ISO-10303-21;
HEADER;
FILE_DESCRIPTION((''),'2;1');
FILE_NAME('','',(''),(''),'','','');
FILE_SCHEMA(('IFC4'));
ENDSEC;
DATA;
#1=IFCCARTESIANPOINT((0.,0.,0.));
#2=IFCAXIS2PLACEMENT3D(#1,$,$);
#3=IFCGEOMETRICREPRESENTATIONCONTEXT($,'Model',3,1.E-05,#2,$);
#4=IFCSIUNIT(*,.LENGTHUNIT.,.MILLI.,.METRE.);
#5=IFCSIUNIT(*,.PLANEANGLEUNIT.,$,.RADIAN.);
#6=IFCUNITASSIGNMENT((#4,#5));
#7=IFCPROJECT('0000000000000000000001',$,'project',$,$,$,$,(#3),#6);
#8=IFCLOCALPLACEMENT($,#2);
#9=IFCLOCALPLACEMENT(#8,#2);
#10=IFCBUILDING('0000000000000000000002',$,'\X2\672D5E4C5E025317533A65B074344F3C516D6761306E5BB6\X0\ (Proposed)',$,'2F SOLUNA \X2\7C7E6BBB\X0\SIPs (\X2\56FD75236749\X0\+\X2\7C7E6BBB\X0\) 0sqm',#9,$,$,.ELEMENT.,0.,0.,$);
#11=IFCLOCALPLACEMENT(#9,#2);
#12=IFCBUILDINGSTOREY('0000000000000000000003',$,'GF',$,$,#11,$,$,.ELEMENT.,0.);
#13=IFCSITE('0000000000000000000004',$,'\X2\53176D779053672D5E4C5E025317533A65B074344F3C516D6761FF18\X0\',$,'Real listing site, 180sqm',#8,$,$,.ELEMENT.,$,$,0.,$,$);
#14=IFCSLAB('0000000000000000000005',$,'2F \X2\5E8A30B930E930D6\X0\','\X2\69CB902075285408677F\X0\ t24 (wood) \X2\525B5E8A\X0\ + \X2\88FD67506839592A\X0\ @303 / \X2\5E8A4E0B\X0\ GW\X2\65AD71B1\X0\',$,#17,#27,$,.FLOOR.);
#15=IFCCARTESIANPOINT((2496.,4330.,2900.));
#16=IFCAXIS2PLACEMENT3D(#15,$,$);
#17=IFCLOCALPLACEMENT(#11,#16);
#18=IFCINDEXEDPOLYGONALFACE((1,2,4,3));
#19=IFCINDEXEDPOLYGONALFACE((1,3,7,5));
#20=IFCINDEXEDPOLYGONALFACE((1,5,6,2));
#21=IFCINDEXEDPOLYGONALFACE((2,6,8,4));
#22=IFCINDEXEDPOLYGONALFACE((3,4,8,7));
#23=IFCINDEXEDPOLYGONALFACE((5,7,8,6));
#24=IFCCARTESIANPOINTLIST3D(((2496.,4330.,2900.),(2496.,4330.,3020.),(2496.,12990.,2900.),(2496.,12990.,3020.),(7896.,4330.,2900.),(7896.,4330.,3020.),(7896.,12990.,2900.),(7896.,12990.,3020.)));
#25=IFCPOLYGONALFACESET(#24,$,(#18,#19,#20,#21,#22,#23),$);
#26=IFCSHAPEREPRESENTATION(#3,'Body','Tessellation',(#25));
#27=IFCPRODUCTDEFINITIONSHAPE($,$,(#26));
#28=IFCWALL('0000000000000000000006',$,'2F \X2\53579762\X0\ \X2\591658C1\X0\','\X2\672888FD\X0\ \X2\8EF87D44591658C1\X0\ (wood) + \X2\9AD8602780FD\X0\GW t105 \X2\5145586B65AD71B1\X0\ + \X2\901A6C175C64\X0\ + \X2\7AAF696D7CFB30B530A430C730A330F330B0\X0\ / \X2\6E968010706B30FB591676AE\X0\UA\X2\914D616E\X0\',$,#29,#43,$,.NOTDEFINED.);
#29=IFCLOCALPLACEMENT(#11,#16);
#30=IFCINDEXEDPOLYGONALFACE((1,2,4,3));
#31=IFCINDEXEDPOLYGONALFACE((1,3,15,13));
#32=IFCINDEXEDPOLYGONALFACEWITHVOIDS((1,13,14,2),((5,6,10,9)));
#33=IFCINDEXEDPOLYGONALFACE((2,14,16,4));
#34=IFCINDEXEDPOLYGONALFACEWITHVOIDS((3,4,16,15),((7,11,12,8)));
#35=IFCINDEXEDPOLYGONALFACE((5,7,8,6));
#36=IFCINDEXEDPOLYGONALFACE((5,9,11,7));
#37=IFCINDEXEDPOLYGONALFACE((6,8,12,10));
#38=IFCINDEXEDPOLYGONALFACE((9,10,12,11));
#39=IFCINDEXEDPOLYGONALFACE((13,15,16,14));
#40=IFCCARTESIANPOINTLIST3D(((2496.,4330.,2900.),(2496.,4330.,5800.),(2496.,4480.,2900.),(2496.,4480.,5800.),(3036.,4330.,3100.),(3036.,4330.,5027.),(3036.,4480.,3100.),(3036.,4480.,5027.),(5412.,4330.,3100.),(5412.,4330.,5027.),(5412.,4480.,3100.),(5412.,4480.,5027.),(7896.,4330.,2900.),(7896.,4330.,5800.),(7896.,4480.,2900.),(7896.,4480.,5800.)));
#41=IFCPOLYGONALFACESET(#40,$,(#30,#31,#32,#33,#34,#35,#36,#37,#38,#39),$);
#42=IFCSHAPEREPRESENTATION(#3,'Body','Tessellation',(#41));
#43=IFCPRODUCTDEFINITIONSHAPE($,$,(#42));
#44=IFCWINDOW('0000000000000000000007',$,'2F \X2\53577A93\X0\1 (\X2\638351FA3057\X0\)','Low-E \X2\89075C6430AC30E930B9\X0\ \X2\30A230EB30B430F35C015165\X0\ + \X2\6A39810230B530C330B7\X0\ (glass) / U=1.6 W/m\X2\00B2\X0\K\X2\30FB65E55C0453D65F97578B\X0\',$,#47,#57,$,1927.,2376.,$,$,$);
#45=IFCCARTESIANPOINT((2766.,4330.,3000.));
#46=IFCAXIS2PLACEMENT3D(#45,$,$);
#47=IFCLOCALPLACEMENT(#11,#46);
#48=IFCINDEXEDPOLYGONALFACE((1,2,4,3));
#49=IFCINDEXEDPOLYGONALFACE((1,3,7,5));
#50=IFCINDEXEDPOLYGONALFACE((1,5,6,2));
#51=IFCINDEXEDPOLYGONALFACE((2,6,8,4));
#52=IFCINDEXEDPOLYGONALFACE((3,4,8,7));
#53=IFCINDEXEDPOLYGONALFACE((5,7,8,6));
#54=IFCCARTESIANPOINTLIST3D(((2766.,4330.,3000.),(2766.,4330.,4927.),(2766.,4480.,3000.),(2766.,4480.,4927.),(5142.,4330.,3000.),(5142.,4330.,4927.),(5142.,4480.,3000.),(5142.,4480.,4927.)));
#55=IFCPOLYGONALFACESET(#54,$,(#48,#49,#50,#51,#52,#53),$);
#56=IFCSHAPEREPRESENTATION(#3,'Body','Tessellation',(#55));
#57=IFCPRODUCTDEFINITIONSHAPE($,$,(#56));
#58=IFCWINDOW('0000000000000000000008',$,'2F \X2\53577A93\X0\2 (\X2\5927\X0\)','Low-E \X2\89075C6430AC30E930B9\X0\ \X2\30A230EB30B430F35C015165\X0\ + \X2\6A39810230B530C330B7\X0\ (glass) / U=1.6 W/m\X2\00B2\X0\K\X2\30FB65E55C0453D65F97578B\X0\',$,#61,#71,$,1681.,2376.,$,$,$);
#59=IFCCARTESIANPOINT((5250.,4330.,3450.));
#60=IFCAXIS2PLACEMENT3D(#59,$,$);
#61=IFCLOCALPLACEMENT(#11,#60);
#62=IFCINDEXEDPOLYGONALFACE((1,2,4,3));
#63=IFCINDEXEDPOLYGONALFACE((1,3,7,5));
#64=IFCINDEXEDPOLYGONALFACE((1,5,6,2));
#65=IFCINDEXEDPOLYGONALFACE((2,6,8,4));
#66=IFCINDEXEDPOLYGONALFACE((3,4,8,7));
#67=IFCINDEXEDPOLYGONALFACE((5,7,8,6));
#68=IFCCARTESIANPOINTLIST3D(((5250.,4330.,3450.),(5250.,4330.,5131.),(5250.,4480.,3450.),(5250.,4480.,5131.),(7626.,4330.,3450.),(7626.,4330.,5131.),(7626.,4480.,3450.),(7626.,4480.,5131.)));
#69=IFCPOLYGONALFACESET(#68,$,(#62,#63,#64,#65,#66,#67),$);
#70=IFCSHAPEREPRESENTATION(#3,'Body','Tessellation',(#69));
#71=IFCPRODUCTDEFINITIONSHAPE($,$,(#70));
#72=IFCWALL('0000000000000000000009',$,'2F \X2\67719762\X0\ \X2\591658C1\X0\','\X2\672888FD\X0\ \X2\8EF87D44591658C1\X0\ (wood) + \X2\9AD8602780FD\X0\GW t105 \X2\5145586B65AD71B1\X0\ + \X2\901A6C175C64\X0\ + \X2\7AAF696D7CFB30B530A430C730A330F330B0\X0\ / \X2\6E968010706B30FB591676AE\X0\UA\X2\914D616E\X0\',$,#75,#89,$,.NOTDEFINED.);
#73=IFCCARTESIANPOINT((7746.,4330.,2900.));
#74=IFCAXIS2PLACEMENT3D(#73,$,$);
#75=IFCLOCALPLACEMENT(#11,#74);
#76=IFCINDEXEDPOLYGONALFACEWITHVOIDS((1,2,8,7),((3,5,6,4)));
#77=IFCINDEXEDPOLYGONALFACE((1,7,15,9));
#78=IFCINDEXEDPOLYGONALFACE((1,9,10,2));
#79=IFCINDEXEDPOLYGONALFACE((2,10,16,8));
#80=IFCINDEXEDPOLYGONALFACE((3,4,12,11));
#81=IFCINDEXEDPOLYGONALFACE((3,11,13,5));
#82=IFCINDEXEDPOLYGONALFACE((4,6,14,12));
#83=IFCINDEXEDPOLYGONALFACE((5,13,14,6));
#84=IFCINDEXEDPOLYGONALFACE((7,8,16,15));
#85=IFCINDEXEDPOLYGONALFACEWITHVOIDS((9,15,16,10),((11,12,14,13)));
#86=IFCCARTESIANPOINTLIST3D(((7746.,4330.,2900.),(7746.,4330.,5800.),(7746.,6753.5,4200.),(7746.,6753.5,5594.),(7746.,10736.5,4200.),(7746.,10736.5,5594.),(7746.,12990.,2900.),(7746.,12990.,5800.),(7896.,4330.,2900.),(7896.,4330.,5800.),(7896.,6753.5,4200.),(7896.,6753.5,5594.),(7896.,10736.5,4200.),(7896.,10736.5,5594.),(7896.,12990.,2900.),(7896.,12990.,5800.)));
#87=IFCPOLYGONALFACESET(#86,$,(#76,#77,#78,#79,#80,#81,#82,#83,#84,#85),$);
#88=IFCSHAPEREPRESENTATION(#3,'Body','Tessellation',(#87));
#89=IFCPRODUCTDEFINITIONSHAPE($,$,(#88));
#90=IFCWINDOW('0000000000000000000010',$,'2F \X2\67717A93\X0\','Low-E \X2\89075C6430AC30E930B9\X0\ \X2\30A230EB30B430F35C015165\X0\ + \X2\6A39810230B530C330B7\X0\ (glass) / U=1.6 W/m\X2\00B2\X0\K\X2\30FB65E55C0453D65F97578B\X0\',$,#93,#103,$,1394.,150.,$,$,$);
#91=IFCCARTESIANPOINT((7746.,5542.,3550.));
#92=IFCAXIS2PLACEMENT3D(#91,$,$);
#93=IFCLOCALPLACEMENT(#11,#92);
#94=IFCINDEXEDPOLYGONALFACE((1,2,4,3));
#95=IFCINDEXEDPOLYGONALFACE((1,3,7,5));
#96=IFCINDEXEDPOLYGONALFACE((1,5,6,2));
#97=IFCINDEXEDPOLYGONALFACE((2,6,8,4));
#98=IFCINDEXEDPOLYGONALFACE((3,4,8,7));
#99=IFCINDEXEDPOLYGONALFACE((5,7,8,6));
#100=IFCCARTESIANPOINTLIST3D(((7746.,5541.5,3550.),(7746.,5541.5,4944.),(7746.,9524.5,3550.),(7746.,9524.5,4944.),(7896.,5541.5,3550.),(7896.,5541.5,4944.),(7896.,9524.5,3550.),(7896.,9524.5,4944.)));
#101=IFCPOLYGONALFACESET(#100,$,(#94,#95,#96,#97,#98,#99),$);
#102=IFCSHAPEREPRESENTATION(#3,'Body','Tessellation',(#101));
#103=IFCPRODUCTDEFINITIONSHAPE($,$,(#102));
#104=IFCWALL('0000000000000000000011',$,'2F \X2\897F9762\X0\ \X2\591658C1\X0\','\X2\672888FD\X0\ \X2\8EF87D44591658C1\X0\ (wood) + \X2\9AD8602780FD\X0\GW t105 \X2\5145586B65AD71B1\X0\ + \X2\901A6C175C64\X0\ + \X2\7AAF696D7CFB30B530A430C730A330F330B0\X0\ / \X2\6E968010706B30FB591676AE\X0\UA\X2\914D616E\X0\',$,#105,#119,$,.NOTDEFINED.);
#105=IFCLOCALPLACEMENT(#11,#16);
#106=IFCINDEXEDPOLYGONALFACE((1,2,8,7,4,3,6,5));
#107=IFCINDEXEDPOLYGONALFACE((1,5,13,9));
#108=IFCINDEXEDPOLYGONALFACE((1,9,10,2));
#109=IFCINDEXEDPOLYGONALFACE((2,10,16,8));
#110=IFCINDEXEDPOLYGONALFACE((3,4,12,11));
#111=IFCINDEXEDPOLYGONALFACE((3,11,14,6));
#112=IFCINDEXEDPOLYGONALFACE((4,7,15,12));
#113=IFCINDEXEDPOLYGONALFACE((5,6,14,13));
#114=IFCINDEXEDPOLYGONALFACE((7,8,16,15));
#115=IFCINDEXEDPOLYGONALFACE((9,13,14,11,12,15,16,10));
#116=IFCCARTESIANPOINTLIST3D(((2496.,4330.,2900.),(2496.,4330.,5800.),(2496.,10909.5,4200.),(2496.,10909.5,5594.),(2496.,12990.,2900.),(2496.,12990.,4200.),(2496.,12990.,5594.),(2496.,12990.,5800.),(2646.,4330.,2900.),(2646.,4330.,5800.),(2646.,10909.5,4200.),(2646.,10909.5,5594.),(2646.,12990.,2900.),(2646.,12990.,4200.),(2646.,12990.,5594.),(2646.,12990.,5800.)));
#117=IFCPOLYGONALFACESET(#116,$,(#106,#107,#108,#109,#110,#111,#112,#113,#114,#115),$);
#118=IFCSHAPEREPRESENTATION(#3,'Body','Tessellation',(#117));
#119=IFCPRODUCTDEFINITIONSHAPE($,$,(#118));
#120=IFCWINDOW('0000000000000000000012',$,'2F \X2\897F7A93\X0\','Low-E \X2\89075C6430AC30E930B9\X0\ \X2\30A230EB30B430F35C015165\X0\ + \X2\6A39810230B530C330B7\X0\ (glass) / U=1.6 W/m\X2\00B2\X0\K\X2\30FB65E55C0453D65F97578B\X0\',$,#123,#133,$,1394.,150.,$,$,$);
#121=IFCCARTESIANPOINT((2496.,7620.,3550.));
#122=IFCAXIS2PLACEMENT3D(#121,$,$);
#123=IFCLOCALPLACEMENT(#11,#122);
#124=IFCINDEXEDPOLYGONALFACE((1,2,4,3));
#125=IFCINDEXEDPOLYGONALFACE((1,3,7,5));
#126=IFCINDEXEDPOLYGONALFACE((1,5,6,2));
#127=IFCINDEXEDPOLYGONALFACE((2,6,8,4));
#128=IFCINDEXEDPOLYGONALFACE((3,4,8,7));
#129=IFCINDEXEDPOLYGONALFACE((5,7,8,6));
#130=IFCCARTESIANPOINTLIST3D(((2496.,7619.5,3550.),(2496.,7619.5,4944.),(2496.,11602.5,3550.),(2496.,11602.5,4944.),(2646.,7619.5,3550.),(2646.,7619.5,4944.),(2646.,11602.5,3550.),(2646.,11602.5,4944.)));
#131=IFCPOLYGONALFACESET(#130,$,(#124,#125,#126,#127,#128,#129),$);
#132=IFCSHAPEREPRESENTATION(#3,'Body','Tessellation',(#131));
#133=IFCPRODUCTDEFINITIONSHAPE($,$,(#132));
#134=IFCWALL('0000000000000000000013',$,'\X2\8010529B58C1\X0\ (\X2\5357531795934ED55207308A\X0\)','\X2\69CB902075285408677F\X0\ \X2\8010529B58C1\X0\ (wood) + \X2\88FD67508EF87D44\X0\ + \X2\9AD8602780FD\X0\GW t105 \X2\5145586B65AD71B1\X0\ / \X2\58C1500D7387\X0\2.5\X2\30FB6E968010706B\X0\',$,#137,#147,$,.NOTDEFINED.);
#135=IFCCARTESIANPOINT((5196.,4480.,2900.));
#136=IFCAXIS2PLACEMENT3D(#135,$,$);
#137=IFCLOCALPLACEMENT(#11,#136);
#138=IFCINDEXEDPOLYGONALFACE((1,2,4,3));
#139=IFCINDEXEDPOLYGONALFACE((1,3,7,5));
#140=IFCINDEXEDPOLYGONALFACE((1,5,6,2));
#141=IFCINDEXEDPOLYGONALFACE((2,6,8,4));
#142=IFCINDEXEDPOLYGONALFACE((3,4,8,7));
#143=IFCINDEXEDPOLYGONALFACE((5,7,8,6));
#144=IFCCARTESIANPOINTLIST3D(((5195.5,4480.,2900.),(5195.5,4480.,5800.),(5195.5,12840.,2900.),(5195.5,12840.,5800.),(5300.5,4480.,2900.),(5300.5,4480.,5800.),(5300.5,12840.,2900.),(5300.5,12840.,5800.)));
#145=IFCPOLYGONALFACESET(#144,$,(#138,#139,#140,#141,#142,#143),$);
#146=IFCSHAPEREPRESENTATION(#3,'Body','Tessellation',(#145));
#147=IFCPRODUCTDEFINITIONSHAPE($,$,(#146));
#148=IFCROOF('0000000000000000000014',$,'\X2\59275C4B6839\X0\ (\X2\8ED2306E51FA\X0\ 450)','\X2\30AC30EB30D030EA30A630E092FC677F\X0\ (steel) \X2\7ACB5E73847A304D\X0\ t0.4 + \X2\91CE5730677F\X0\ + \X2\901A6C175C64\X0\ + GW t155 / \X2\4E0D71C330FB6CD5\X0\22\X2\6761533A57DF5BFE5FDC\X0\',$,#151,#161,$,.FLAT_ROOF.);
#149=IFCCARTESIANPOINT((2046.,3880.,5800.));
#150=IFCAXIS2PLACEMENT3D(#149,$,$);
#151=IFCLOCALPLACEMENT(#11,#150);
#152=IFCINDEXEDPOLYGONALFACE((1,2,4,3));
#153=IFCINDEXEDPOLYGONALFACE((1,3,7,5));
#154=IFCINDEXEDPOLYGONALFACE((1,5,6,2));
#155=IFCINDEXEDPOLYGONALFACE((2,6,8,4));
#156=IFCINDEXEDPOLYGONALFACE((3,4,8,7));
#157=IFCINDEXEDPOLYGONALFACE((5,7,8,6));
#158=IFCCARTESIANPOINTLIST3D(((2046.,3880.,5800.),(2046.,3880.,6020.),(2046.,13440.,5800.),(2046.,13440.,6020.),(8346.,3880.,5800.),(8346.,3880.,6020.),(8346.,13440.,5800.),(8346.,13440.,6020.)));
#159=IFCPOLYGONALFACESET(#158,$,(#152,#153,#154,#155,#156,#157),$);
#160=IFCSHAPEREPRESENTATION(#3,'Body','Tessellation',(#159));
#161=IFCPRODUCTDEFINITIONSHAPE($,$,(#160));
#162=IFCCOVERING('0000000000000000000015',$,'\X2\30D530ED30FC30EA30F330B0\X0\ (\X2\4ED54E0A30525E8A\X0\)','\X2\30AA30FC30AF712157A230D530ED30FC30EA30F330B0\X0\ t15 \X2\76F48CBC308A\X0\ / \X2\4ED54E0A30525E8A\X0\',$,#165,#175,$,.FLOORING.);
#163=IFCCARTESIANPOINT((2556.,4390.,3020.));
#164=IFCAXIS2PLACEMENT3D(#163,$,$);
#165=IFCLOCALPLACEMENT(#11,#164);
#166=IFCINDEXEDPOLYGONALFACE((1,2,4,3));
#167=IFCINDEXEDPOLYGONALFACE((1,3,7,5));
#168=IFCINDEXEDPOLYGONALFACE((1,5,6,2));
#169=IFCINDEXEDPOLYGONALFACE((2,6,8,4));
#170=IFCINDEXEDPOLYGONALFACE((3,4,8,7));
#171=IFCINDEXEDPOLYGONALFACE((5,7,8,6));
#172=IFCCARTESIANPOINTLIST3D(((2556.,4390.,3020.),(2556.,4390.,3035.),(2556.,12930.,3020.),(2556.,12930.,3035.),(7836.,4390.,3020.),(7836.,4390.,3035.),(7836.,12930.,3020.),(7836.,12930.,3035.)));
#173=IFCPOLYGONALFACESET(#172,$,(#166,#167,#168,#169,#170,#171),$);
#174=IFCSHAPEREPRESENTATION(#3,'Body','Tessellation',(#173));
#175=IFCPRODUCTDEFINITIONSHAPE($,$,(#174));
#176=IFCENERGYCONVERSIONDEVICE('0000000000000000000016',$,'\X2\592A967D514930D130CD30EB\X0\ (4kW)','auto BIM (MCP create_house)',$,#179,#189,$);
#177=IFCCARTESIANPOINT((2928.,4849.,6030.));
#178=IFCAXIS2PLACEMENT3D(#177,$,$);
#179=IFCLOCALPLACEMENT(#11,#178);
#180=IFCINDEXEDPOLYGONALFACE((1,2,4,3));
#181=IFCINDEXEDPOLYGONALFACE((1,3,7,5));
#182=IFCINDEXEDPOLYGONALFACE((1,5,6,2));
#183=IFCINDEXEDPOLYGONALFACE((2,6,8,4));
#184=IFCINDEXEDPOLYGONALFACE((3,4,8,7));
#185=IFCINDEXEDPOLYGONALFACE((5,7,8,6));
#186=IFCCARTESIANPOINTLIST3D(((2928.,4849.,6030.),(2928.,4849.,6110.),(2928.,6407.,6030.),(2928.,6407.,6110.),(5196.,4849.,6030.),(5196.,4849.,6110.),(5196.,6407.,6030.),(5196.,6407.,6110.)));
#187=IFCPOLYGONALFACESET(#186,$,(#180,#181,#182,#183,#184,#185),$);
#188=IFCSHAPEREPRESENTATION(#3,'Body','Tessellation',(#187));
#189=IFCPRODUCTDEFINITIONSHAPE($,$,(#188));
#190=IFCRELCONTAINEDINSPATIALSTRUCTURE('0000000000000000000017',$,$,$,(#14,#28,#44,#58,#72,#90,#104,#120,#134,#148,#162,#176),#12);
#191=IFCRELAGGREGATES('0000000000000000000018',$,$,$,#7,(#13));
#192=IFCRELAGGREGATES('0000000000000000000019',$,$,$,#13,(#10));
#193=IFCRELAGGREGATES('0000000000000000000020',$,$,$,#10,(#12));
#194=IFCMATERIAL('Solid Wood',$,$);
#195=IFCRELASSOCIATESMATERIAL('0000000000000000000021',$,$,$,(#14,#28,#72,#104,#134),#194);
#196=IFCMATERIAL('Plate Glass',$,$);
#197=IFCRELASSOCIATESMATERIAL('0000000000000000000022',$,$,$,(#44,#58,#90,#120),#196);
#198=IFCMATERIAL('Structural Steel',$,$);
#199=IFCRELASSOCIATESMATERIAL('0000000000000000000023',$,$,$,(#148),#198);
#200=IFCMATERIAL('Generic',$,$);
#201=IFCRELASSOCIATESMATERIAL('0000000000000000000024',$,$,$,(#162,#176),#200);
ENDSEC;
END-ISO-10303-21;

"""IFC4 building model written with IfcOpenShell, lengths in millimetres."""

from ifc_helpers import new_model, si_unit, frame, frame_2d, origin, place, context, project, spatial, rectangle, extrude, material, element, fill, save


model = new_model("IFC4")

# Units and contexts
model_context = context("Model", 3, precision=1e-05, world=origin())
ifc_project = project(units=[si_unit("LENGTHUNIT", "METRE", prefix="MILLI"), si_unit("PLANEANGLEUNIT", "RADIAN")], contexts=[model_context])

# Site, building, storey
site_placement = place(None, origin())
site = spatial("IfcSite", under=ifc_project, at=site_placement, Name="北海道札幌市北区新琴似六条８", ObjectType="Real listing site, 180sqm", CompositionType="ELEMENT", RefElevation=0.0)
building_placement = place(site_placement, origin())
building = spatial("IfcBuilding", under=site, at=building_placement, Name="札幌市北区新琴似六条の家 (Proposed)", ObjectType="2F SOLUNA 籾殻SIPs (国産杉+籾殻) 0sqm", CompositionType="ELEMENT", ElevationOfRefHeight=0.0, ElevationOfTerrain=0.0)
storey_placement = place(building_placement, origin())
storey = spatial("IfcBuildingStorey", under=building, at=storey_placement, Name="GF", CompositionType="ELEMENT", Elevation=0.0)

# Slab
ifc_material_1 = material(Name="Solid Wood")
slab_placement = place(storey_placement, frame((2496.0, 4330.0, 2900.0)))
element("IfcSlab", 1, at=slab_placement, inside=storey, material=ifc_material_1, Name="2F 床スラブ", Description="構造用合板 t24 (wood) 剛床 + 製材根太 @303 / 床下 GW断熱", PredefinedType="FLOOR", context=model_context, shape_type="SweptSolid", body=[
    extrude(rectangle(XDim=5400.0, YDim=8660.0, at=frame_2d((2700.0, 4330.0))), frame((2496.0, 4330.0, 2900.0)), (0.0, 0.0, 1.0), 120.0),
])

# Wall, openings, windows
wall_1_placement = place(storey_placement, frame((2496.0, 4330.0, 2900.0)))
wall_1 = element("IfcWall", 2, at=wall_1_placement, inside=storey, material=ifc_material_1, Name="2F 南面 外壁", Description="木製 軸組外壁 (wood) + 高性能GW t105 充填断熱 + 通気層 + 窯業系サイディング / 準耐火・外皮UA配慮", PredefinedType="NOTDEFINED", context=model_context, shape_type="SweptSolid", body=[
    extrude(rectangle(XDim=5400.0, YDim=150.0, at=frame_2d((2700.0, 75.0))), frame((2496.0, 4330.0, 2900.0)), (0.0, 0.0, 1.0), 2900.0),
])
opening_1_placement = place(storey_placement, frame((2766.0, 4330.0, 3000.0)))
opening_1 = element("IfcOpeningElement", 3, at=opening_1_placement, cuts=wall_1, PredefinedType="NOTDEFINED", context=model_context, shape_type="SweptSolid", body=[
    extrude(rectangle(XDim=2376.0, YDim=150.0, at=frame_2d((1188.0, 75.0))), frame((2766.0, 4330.0, 3000.0)), (0.0, 0.0, 1.0), 1927.0),
])
opening_2_placement = place(storey_placement, frame((5250.0, 4330.0, 3450.0)))
opening_2 = element("IfcOpeningElement", 4, at=opening_2_placement, cuts=wall_1, PredefinedType="NOTDEFINED", context=model_context, shape_type="SweptSolid", body=[
    extrude(rectangle(XDim=2376.0, YDim=150.0, at=frame_2d((1188.0, 75.0))), frame((5250.0, 4330.0, 3450.0)), (0.0, 0.0, 1.0), 1681.0),
])
ifc_material_2 = material(Name="Plate Glass")
window_1_placement = place(storey_placement, frame((2766.0, 4330.0, 3000.0)))
window_1 = element("IfcWindow", 5, at=window_1_placement, inside=storey, material=ifc_material_2, Name="2F 南窓1 (掃出し)", Description="Low-E 複層ガラス アルゴン封入 + 樹脂サッシ (glass) / U=1.6 W/m²K・日射取得型", OverallHeight=1927.0, OverallWidth=2376.0, context=model_context, shape_type="SweptSolid", body=[
    extrude(rectangle(XDim=2376.0, YDim=150.0, at=frame_2d((1188.0, 75.0))), frame((2766.0, 4330.0, 3000.0)), (0.0, 0.0, 1.0), 1927.0),
])
fill(opening_1, window_1)
window_2_placement = place(storey_placement, frame((5250.0, 4330.0, 3450.0)))
window_2 = element("IfcWindow", 6, at=window_2_placement, inside=storey, material=ifc_material_2, Name="2F 南窓2 (大)", Description="Low-E 複層ガラス アルゴン封入 + 樹脂サッシ (glass) / U=1.6 W/m²K・日射取得型", OverallHeight=1681.0, OverallWidth=2376.0, context=model_context, shape_type="SweptSolid", body=[
    extrude(rectangle(XDim=2376.0, YDim=150.0, at=frame_2d((1188.0, 75.0))), frame((5250.0, 4330.0, 3450.0)), (0.0, 0.0, 1.0), 1681.0),
])
fill(opening_2, window_2)

# Walls, openings, windows
wall_2_placement = place(storey_placement, frame((7746.0, 4330.0, 2900.0)))
wall_2 = element("IfcWall", 7, at=wall_2_placement, inside=storey, material=ifc_material_1, Name="2F 東面 外壁", Description="木製 軸組外壁 (wood) + 高性能GW t105 充填断熱 + 通気層 + 窯業系サイディング / 準耐火・外皮UA配慮", PredefinedType="NOTDEFINED", context=model_context, shape_type="SweptSolid", body=[
    extrude(rectangle(XDim=150.0, YDim=8660.0, at=frame_2d((75.0, 4330.0))), frame((7746.0, 4330.0, 2900.0)), (0.0, 0.0, 1.0), 2900.0),
])
opening_3_placement = place(storey_placement, frame((7746.0, 5542.0, 3550.0)))
opening_3 = element("IfcOpeningElement", 8, at=opening_3_placement, cuts=wall_2, PredefinedType="NOTDEFINED", context=model_context, shape_type="SweptSolid", body=[
    extrude(rectangle(XDim=150.0, YDim=3983.0, at=frame_2d((75.0, 1991.0))), frame((7746.0, 5542.0, 3550.0)), (0.0, 0.0, 1.0), 1394.0),
])
window_3_placement = place(storey_placement, frame((7746.0, 5542.0, 3550.0)))
window_3 = element("IfcWindow", 9, at=window_3_placement, inside=storey, material=ifc_material_2, Name="2F 東窓", Description="Low-E 複層ガラス アルゴン封入 + 樹脂サッシ (glass) / U=1.6 W/m²K・日射取得型", OverallHeight=1394.0, OverallWidth=150.0, context=model_context, shape_type="SweptSolid", body=[
    extrude(rectangle(XDim=150.0, YDim=3983.0, at=frame_2d((75.0, 1991.0))), frame((7746.0, 5542.0, 3550.0)), (0.0, 0.0, 1.0), 1394.0),
])
fill(opening_3, window_3)
wall_3_placement = place(storey_placement, frame((2496.0, 4330.0, 2900.0)))
wall_3 = element("IfcWall", 10, at=wall_3_placement, inside=storey, material=ifc_material_1, Name="2F 西面 外壁", Description="木製 軸組外壁 (wood) + 高性能GW t105 充填断熱 + 通気層 + 窯業系サイディング / 準耐火・外皮UA配慮", PredefinedType="NOTDEFINED", context=model_context, shape_type="SweptSolid", body=[
    extrude(rectangle(XDim=150.0, YDim=8660.0, at=frame_2d((75.0, 4330.0))), frame((2496.0, 4330.0, 2900.0)), (0.0, 0.0, 1.0), 2900.0),
])
opening_4_placement = place(storey_placement, frame((2496.0, 7620.0, 3550.0)))
opening_4 = element("IfcOpeningElement", 11, at=opening_4_placement, cuts=wall_3, PredefinedType="NOTDEFINED", context=model_context, shape_type="SweptSolid", body=[
    extrude(rectangle(XDim=150.0, YDim=3983.0, at=frame_2d((75.0, 1991.0))), frame((2496.0, 7620.0, 3550.0)), (0.0, 0.0, 1.0), 1394.0),
])
window_4_placement = place(storey_placement, frame((2496.0, 7620.0, 3550.0)))
window_4 = element("IfcWindow", 12, at=window_4_placement, inside=storey, material=ifc_material_2, Name="2F 西窓", Description="Low-E 複層ガラス アルゴン封入 + 樹脂サッシ (glass) / U=1.6 W/m²K・日射取得型", OverallHeight=1394.0, OverallWidth=150.0, context=model_context, shape_type="SweptSolid", body=[
    extrude(rectangle(XDim=150.0, YDim=3983.0, at=frame_2d((75.0, 1991.0))), frame((2496.0, 7620.0, 3550.0)), (0.0, 0.0, 1.0), 1394.0),
])
fill(opening_4, window_4)

# Wall
wall_4_placement = place(storey_placement, frame((5196.0, 4480.0, 2900.0)))
element("IfcWall", 13, at=wall_4_placement, inside=storey, material=ifc_material_1, Name="耐力壁 (南北間仕切り)", Description="構造用合板 耐力壁 (wood) + 製材軸組 + 高性能GW t105 充填断熱 / 壁倍率2.5・準耐火", PredefinedType="NOTDEFINED", context=model_context, shape_type="SweptSolid", body=[
    extrude(rectangle(XDim=105.0, YDim=8360.0, at=frame_2d((52.0, 4180.0))), frame((5196.0, 4480.0, 2900.0)), (0.0, 0.0, 1.0), 2900.0),
])

# Roof
ifc_material_3 = material(Name="Structural Steel")
roof_placement = place(storey_placement, frame((2046.0, 3880.0, 5800.0)))
element("IfcRoof", 14, at=roof_placement, inside=storey, material=ifc_material_3, Name="大屋根 (軒の出 450)", Description="ガルバリウム鋼板 (steel) 立平葺き t0.4 + 野地板 + 通気層 + GW t155 / 不燃・法22条区域対応", PredefinedType="FLAT_ROOF", context=model_context, shape_type="SweptSolid", body=[
    extrude(rectangle(XDim=6300.0, YDim=9560.0, at=frame_2d((3150.0, 4780.0))), frame((2046.0, 3880.0, 5800.0)), (0.0, 0.0, 1.0), 220.0),
])

# Covering
ifc_material_4 = material(Name="Generic")
covering_placement = place(storey_placement, frame((2556.0, 4390.0, 3020.0)))
element("IfcCovering", 15, at=covering_placement, inside=storey, material=ifc_material_4, Name="フローリング (仕上げ床)", Description="オーク無垢フローリング t15 直貼り / 仕上げ床", PredefinedType="FLOORING", context=model_context, shape_type="SweptSolid", body=[
    extrude(rectangle(XDim=5280.0, YDim=8540.0, at=frame_2d((2640.0, 4270.0))), frame((2556.0, 4390.0, 3020.0)), (0.0, 0.0, 1.0), 15.0),
])

# Energy conversion device
energy_conversion_device_placement = place(storey_placement, frame((2928.0, 4849.0, 6030.0)))
element("IfcEnergyConversionDevice", 16, at=energy_conversion_device_placement, inside=storey, material=ifc_material_4, Name="太陽光パネル (4kW)", Description="auto BIM (MCP create_house)", context=model_context, shape_type="SweptSolid", body=[
    extrude(rectangle(XDim=2268.0, YDim=1558.0, at=frame_2d((1134.0, 779.0))), frame((2928.0, 4849.0, 6030.0)), (0.0, 0.0, 1.0), 80.0),
])

save(model, "model.ifc")
